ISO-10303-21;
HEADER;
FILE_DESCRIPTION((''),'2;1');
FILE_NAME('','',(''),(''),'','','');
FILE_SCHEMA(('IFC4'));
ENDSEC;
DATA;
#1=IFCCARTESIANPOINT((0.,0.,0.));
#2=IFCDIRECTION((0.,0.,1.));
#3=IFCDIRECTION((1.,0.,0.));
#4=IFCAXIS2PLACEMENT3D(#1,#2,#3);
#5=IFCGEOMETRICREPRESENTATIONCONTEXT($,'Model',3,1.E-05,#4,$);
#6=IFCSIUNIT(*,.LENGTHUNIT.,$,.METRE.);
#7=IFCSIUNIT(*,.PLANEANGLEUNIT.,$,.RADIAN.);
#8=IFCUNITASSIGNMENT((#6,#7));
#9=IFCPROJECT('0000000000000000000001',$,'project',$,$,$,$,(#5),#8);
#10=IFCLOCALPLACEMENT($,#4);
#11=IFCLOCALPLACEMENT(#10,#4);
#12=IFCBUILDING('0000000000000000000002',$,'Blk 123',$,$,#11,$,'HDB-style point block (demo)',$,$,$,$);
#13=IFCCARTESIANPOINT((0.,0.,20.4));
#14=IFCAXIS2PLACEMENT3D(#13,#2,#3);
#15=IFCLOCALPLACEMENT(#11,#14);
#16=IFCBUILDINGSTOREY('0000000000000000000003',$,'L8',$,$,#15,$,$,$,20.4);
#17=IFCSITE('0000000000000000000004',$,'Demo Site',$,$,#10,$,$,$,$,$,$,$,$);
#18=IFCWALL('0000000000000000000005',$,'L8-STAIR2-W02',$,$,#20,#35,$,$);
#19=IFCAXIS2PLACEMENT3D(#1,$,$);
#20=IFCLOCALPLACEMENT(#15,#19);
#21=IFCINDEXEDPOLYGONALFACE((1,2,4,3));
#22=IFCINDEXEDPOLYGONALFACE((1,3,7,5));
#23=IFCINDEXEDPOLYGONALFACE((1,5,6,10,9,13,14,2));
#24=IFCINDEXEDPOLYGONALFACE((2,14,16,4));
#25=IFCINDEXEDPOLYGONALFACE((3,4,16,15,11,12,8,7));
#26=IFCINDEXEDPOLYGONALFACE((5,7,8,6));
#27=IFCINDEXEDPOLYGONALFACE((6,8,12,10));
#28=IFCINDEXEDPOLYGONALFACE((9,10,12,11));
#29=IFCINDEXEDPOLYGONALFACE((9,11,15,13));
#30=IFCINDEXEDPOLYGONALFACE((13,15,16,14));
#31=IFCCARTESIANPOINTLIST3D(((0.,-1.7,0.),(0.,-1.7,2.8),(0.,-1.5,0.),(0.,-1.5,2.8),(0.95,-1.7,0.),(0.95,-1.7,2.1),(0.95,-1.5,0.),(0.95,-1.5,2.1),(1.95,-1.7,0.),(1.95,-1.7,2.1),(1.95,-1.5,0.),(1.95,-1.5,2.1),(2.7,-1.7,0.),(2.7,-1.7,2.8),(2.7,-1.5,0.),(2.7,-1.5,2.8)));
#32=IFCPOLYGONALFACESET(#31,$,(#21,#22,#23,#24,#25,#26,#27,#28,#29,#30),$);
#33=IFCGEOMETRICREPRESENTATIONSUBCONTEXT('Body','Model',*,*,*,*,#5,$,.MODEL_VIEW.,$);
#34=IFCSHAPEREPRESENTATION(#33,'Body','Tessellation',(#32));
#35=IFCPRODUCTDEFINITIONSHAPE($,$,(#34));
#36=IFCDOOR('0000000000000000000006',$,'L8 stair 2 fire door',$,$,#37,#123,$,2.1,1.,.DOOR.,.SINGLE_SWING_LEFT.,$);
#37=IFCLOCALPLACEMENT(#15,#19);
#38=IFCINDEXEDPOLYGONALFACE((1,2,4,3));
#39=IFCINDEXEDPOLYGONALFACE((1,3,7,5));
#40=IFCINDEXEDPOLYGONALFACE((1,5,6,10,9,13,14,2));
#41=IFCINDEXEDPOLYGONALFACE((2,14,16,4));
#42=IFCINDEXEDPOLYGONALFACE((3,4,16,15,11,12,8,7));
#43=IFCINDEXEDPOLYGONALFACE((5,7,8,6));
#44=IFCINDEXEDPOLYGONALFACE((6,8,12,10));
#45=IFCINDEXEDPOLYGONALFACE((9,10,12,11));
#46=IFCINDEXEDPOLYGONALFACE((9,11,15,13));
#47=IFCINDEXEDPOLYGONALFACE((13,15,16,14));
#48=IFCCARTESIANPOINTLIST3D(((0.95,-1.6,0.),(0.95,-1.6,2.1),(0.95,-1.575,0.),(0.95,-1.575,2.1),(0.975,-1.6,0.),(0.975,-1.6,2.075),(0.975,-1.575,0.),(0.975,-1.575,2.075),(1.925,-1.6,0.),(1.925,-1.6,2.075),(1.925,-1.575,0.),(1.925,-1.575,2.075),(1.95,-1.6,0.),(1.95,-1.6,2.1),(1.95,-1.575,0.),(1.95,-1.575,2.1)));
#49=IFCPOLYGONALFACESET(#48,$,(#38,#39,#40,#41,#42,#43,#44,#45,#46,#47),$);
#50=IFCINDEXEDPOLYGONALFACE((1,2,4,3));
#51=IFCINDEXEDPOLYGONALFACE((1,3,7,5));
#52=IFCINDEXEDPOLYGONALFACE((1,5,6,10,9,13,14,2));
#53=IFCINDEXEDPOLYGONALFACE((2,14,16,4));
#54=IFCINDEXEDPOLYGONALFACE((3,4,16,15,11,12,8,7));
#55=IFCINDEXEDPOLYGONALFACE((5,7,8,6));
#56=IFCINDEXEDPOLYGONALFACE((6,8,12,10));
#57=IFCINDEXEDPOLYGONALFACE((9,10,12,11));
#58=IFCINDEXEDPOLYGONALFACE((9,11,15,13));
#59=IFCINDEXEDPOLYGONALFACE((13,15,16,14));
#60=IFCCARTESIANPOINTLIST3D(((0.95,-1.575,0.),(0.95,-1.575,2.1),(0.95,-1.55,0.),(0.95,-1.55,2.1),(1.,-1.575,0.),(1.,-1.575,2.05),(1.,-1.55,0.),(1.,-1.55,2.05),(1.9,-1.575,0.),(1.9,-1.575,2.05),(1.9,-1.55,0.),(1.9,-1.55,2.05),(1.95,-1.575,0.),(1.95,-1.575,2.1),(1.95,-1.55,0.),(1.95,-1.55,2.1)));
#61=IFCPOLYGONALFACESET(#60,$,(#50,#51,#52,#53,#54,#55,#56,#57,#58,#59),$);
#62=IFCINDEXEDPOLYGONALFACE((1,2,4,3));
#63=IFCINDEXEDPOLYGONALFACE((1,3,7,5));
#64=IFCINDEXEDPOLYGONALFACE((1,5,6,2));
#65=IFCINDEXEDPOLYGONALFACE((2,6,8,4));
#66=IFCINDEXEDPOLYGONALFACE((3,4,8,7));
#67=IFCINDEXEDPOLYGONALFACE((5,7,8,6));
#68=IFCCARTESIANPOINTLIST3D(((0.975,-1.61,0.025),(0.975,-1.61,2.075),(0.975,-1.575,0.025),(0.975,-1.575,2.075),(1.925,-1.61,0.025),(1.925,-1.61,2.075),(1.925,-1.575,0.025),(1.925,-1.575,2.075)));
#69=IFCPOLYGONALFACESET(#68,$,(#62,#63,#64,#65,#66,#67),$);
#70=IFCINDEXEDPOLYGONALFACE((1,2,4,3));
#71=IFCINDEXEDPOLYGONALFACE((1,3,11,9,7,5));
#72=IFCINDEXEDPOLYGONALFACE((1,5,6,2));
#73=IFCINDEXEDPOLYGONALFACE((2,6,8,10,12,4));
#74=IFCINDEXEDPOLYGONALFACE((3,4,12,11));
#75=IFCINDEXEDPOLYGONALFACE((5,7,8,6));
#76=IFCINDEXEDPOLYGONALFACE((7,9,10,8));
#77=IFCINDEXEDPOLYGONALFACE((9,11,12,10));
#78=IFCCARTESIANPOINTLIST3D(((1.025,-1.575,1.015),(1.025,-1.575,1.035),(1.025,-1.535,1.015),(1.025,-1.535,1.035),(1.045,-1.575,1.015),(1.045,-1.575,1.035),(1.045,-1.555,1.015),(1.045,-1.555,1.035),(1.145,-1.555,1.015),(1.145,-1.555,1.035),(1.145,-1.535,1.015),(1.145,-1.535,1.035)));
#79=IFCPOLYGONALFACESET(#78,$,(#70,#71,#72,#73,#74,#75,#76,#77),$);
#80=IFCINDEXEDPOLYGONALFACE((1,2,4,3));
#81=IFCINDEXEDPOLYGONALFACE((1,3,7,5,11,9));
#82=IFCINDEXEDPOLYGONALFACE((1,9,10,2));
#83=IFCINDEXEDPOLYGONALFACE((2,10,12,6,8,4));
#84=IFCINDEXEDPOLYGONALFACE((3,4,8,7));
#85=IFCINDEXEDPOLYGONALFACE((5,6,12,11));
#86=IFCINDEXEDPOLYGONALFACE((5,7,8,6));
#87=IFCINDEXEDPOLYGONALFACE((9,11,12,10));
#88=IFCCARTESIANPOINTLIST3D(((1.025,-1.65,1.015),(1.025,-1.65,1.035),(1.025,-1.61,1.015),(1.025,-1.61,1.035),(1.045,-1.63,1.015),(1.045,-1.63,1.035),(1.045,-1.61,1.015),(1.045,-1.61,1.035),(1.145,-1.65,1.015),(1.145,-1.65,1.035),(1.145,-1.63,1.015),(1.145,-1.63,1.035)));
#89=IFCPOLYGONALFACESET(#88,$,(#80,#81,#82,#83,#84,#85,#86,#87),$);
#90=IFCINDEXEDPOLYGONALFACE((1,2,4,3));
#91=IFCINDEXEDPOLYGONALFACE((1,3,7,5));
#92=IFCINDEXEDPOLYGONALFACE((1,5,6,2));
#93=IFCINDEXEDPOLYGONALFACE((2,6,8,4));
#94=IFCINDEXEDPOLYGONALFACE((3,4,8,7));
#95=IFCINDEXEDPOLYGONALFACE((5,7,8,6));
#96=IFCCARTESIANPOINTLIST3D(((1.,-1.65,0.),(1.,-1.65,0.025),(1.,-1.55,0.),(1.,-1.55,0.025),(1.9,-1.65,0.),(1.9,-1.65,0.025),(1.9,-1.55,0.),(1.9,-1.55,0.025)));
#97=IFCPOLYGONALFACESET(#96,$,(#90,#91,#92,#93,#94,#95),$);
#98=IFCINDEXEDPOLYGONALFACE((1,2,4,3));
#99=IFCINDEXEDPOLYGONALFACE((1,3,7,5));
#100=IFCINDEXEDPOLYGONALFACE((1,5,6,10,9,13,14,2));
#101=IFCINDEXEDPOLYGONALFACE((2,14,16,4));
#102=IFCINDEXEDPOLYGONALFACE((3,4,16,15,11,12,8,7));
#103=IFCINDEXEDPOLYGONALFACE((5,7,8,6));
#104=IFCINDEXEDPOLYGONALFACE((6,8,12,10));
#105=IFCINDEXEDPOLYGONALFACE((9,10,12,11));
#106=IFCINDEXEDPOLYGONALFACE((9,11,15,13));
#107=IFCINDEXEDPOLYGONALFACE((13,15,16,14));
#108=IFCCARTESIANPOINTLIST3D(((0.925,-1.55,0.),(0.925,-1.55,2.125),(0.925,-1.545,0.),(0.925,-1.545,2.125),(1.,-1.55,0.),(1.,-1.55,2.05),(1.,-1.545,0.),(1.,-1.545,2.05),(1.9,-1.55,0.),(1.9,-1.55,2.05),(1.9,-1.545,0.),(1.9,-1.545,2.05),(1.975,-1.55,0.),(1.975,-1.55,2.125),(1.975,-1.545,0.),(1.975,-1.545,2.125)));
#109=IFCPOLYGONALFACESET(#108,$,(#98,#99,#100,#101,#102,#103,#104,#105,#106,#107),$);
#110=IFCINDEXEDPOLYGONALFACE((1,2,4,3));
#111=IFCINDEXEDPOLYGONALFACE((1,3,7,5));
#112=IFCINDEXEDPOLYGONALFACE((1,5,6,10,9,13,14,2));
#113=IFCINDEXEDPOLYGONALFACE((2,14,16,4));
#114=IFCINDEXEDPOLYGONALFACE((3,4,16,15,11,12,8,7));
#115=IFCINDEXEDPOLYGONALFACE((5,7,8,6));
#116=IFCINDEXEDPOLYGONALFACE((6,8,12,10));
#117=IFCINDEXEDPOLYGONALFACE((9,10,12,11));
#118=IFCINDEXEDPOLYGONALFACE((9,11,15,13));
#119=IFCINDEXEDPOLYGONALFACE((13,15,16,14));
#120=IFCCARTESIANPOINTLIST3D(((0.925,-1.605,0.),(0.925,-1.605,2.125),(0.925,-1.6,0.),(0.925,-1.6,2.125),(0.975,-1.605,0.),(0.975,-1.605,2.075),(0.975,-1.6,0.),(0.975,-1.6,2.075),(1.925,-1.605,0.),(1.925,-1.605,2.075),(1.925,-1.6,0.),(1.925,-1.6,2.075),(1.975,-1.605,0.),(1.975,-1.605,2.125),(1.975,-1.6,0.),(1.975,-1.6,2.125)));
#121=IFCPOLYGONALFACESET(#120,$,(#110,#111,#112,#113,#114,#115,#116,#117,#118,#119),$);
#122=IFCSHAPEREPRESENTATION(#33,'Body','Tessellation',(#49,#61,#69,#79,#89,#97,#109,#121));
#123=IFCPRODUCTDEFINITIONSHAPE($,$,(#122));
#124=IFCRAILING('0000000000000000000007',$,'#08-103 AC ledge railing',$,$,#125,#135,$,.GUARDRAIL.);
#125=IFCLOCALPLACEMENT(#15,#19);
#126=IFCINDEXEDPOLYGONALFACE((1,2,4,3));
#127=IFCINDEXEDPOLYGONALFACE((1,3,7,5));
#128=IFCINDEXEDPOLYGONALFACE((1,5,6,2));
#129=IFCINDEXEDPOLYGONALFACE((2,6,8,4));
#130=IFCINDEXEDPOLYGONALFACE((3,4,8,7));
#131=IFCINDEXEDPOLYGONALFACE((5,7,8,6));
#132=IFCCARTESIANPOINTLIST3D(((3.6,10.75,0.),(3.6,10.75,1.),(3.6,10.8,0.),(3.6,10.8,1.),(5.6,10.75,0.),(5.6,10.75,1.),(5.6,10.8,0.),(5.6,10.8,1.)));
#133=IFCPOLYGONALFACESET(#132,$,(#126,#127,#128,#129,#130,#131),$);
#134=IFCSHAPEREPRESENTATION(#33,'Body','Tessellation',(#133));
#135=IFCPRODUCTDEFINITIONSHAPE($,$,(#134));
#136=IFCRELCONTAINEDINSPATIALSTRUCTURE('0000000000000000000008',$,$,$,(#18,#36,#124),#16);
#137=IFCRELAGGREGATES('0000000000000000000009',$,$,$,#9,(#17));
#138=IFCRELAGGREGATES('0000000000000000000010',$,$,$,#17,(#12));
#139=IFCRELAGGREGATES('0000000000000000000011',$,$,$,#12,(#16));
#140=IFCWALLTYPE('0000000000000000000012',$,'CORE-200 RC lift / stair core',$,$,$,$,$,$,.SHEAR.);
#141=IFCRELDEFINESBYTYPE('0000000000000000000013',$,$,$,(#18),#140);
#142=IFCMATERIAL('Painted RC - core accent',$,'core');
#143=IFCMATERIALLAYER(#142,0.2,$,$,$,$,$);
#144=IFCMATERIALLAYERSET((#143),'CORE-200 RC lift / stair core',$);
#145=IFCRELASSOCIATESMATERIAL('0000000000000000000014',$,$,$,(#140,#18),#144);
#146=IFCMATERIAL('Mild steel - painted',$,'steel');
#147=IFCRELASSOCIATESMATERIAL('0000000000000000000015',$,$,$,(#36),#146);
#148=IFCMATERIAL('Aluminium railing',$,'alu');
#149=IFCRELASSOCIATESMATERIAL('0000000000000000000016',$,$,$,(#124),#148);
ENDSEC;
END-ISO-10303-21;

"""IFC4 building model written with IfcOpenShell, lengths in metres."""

from ifc_helpers import new_model, si_unit, frame, origin, origin_with_axes, place, context, subcontext, project, spatial, polyline, line, indexed_curve, outline, extrude, material, layer, layer_set, layer_usage, type_object, element, fill, save


model = new_model("IFC4")

# Units and contexts
model_context = context("Model", 3, precision=1e-05, world=origin_with_axes())
body_context = subcontext(model_context, "Body", "Model", "MODEL_VIEW")
ifc_project = project(units=[si_unit("LENGTHUNIT", "METRE"), si_unit("PLANEANGLEUNIT", "RADIAN")], contexts=[model_context])

# Site, building, storey
site_placement = place(None, origin_with_axes())
site = spatial("IfcSite", under=ifc_project, at=site_placement, Name="Demo Site")
building_placement = place(site_placement, origin_with_axes())
building = spatial("IfcBuilding", under=site, at=building_placement, Name="Blk 123", LongName="HDB-style point block (demo)")
storey_placement = place(building_placement, frame((0.0, 0.0, 20.4), z_axis=(0.0, 0.0, 1.0), x_axis=(1.0, 0.0, 0.0)))
storey = spatial("IfcBuildingStorey", under=building, at=storey_placement, Name="L8", Elevation=20.4)

# Shared definitions
ifc_material_1 = material(Name="Painted RC - core accent", Category="core")
ifc_layer_1 = layer(ifc_material_1, 0.2)
ifc_layer_set_1 = layer_set([ifc_layer_1], Name="CORE-200 RC lift / stair core")
ifc_layer_usage_1 = layer_usage(ifc_layer_set_1, "AXIS2", "POSITIVE", 0.0)
wall_type_1 = type_object("IfcWallType", Name="CORE-200 RC lift / stair core", PredefinedType="SHEAR", material=ifc_layer_set_1)

# Wall, opening, door
wall_1_placement = place(storey_placement, frame((2.7, -1.5, 0.0), z_axis=(0.0, 0.0, 1.0), x_axis=(-1.0, 0.0, 0.0)))
wall_1 = element("IfcWall", 1, at=wall_1_placement, inside=storey, type_object=wall_type_1, material=ifc_layer_usage_1, Name="L8-STAIR2-W02", context=body_context, shape_type="SweptSolid", body=[
    extrude(outline(indexed_curve([(0.0, 0.0), (0.0, 0.2), (2.7, 0.2), (2.7, 0.0), (0.0, 0.0)], self_intersect=False)), origin_with_axes(), (0.0, 0.0, 1.0), 2.8),
])
opening_1_placement = place(wall_1_placement, frame((0.75, -0.1, 0.0), z_axis=(0.0, 0.0, 1.0), x_axis=(1.0, 0.0, 0.0)))
opening_1 = element("IfcOpeningElement", 2, at=opening_1_placement, cuts=wall_1, context=body_context, shape_type="SweptSolid", body=[
    extrude(outline(indexed_curve([(0.0, 0.0), (0.0, 0.4), (1.0, 0.4), (1.0, 0.0), (0.0, 0.0)], self_intersect=False)), origin_with_axes(), (0.0, 0.0, 1.0), 2.1),
])
ifc_material_2 = material(Name="Mild steel - painted", Category="steel")
door_1_placement = place(opening_1_placement, frame((0.0, 0.15, 0.0), z_axis=(0.0, 0.0, 1.0), x_axis=(1.0, 0.0, 0.0)))
door_1 = element("IfcDoor", 3, at=door_1_placement, inside=storey, material=ifc_material_2, Name="L8 stair 2 fire door", OperationType="SINGLE_SWING_LEFT", OverallHeight=2.1, OverallWidth=1.0, PredefinedType="DOOR", context=body_context, shape_type="SweptSolid", body=[
    extrude(outline(indexed_curve([(0.0, 0.0), (0.0, 2.1), (1.0, 2.1), (1.0, 0.0), (0.975, 0.0), (0.975, 2.075), (0.025, 2.075), (0.025, 0.0)], segments=[line(1, 2, 3, 4, 5, 6, 7, 8, 1)])), frame((0.0, 0.025, 0.0), z_axis=(0.0, -1.0, 0.0), x_axis=(1.0, 0.0, 0.0)), (0.0, 0.0, -1.0), 0.025),
    extrude(outline(indexed_curve([(0.0, 0.0), (0.0, 2.1), (1.0, 2.1), (1.0, 0.0), (0.95, 0.0), (0.95, 2.05), (0.05, 2.05), (0.05, 0.0)], segments=[line(1, 2, 3, 4, 5, 6, 7, 8, 1)])), frame((0.0, 0.0, 0.0), z_axis=(0.0, -1.0, 0.0), x_axis=(1.0, 0.0, 0.0)), (0.0, 0.0, -1.0), 0.025),
    extrude(outline(indexed_curve([(0.0, 0.0), (0.95, 0.0), (0.95, 0.035), (0.0, 0.035)], segments=[line(1, 2, 3, 4, 1)])), frame((0.025, 0.025, 0.025), z_axis=(0.0, 0.0, 1.0), x_axis=(1.0, 0.0, 0.0)), (0.0, 0.0, 1.0), 2.05),
    extrude(outline(indexed_curve([(0.0, 0.0), (0.0, -0.04), (-0.12, -0.04), (-0.12, -0.02), (-0.02, -0.02), (-0.02, 0.0)], segments=[line(1, 2, 3, 4, 5, 6, 1)])), frame((0.925, 0.025, 1.015), z_axis=(0.0, 0.0, 1.0), x_axis=(1.0, 0.0, 0.0)), (0.0, 0.0, 1.0), 0.02),
    extrude(outline(indexed_curve([(0.0, 0.0), (0.0, 0.04), (-0.12, 0.04), (-0.12, 0.02), (-0.02, 0.02), (-0.02, 0.0)], segments=[line(1, 2, 3, 4, 5, 6, 1)])), frame((0.925, 0.06, 1.015), z_axis=(0.0, 0.0, 1.0), x_axis=(1.0, 0.0, 0.0)), (0.0, 0.0, 1.0), 0.02),
    extrude(outline(indexed_curve([(0.0, 0.0), (0.9, 0.0), (0.9, 0.1), (0.0, 0.1)], segments=[line(1, 2, 3, 4, 1)])), frame((0.05, 0.0, 0.0), z_axis=(0.0, 0.0, 1.0), x_axis=(1.0, 0.0, 0.0)), (0.0, 0.0, 1.0), 0.025),
    extrude(outline(indexed_curve([(0.0, 0.0), (0.0, 2.125), (1.05, 2.125), (1.05, 0.0), (0.975, 0.0), (0.975, 2.05), (0.075, 2.05), (0.075, 0.0)], segments=[line(1, 2, 3, 4, 5, 6, 7, 8, 1)])), frame((-0.025, -0.005, 0.0), z_axis=(0.0, -1.0, 0.0), x_axis=(1.0, 0.0, 0.0)), (0.0, 0.0, -1.0), 0.005),
    extrude(outline(indexed_curve([(0.0, 0.0), (0.0, 2.125), (1.05, 2.125), (1.05, 0.0), (1.0, 0.0), (1.0, 2.075), (0.05, 2.075), (0.05, 0.0)], segments=[line(1, 2, 3, 4, 5, 6, 7, 8, 1)])), frame((-0.025, 0.05, 0.0), z_axis=(0.0, -1.0, 0.0), x_axis=(1.0, 0.0, 0.0)), (0.0, 0.0, -1.0), 0.005),
])
fill(opening_1, door_1)

# Railing
ifc_material_3 = material(Name="Aluminium railing", Category="alu")
railing_placement = place(storey_placement, frame((4.6, 10.775, 0.0), z_axis=(0.0, 0.0, 1.0), x_axis=(1.0, 0.0, 0.0)))
element("IfcRailing", 4, at=railing_placement, inside=storey, material=ifc_material_3, Name="#08-103 AC ledge railing", PredefinedType="GUARDRAIL", context=body_context, shape_type="SweptSolid", body=[
    extrude(outline(polyline([(1.0, -0.025), (1.0, 0.025), (-1.0, 0.025), (-1.0, -0.025), (1.0, -0.025)])), origin(), (0.0, 0.0, 1.0), 1.0),
])

save(model, "model.ifc")
